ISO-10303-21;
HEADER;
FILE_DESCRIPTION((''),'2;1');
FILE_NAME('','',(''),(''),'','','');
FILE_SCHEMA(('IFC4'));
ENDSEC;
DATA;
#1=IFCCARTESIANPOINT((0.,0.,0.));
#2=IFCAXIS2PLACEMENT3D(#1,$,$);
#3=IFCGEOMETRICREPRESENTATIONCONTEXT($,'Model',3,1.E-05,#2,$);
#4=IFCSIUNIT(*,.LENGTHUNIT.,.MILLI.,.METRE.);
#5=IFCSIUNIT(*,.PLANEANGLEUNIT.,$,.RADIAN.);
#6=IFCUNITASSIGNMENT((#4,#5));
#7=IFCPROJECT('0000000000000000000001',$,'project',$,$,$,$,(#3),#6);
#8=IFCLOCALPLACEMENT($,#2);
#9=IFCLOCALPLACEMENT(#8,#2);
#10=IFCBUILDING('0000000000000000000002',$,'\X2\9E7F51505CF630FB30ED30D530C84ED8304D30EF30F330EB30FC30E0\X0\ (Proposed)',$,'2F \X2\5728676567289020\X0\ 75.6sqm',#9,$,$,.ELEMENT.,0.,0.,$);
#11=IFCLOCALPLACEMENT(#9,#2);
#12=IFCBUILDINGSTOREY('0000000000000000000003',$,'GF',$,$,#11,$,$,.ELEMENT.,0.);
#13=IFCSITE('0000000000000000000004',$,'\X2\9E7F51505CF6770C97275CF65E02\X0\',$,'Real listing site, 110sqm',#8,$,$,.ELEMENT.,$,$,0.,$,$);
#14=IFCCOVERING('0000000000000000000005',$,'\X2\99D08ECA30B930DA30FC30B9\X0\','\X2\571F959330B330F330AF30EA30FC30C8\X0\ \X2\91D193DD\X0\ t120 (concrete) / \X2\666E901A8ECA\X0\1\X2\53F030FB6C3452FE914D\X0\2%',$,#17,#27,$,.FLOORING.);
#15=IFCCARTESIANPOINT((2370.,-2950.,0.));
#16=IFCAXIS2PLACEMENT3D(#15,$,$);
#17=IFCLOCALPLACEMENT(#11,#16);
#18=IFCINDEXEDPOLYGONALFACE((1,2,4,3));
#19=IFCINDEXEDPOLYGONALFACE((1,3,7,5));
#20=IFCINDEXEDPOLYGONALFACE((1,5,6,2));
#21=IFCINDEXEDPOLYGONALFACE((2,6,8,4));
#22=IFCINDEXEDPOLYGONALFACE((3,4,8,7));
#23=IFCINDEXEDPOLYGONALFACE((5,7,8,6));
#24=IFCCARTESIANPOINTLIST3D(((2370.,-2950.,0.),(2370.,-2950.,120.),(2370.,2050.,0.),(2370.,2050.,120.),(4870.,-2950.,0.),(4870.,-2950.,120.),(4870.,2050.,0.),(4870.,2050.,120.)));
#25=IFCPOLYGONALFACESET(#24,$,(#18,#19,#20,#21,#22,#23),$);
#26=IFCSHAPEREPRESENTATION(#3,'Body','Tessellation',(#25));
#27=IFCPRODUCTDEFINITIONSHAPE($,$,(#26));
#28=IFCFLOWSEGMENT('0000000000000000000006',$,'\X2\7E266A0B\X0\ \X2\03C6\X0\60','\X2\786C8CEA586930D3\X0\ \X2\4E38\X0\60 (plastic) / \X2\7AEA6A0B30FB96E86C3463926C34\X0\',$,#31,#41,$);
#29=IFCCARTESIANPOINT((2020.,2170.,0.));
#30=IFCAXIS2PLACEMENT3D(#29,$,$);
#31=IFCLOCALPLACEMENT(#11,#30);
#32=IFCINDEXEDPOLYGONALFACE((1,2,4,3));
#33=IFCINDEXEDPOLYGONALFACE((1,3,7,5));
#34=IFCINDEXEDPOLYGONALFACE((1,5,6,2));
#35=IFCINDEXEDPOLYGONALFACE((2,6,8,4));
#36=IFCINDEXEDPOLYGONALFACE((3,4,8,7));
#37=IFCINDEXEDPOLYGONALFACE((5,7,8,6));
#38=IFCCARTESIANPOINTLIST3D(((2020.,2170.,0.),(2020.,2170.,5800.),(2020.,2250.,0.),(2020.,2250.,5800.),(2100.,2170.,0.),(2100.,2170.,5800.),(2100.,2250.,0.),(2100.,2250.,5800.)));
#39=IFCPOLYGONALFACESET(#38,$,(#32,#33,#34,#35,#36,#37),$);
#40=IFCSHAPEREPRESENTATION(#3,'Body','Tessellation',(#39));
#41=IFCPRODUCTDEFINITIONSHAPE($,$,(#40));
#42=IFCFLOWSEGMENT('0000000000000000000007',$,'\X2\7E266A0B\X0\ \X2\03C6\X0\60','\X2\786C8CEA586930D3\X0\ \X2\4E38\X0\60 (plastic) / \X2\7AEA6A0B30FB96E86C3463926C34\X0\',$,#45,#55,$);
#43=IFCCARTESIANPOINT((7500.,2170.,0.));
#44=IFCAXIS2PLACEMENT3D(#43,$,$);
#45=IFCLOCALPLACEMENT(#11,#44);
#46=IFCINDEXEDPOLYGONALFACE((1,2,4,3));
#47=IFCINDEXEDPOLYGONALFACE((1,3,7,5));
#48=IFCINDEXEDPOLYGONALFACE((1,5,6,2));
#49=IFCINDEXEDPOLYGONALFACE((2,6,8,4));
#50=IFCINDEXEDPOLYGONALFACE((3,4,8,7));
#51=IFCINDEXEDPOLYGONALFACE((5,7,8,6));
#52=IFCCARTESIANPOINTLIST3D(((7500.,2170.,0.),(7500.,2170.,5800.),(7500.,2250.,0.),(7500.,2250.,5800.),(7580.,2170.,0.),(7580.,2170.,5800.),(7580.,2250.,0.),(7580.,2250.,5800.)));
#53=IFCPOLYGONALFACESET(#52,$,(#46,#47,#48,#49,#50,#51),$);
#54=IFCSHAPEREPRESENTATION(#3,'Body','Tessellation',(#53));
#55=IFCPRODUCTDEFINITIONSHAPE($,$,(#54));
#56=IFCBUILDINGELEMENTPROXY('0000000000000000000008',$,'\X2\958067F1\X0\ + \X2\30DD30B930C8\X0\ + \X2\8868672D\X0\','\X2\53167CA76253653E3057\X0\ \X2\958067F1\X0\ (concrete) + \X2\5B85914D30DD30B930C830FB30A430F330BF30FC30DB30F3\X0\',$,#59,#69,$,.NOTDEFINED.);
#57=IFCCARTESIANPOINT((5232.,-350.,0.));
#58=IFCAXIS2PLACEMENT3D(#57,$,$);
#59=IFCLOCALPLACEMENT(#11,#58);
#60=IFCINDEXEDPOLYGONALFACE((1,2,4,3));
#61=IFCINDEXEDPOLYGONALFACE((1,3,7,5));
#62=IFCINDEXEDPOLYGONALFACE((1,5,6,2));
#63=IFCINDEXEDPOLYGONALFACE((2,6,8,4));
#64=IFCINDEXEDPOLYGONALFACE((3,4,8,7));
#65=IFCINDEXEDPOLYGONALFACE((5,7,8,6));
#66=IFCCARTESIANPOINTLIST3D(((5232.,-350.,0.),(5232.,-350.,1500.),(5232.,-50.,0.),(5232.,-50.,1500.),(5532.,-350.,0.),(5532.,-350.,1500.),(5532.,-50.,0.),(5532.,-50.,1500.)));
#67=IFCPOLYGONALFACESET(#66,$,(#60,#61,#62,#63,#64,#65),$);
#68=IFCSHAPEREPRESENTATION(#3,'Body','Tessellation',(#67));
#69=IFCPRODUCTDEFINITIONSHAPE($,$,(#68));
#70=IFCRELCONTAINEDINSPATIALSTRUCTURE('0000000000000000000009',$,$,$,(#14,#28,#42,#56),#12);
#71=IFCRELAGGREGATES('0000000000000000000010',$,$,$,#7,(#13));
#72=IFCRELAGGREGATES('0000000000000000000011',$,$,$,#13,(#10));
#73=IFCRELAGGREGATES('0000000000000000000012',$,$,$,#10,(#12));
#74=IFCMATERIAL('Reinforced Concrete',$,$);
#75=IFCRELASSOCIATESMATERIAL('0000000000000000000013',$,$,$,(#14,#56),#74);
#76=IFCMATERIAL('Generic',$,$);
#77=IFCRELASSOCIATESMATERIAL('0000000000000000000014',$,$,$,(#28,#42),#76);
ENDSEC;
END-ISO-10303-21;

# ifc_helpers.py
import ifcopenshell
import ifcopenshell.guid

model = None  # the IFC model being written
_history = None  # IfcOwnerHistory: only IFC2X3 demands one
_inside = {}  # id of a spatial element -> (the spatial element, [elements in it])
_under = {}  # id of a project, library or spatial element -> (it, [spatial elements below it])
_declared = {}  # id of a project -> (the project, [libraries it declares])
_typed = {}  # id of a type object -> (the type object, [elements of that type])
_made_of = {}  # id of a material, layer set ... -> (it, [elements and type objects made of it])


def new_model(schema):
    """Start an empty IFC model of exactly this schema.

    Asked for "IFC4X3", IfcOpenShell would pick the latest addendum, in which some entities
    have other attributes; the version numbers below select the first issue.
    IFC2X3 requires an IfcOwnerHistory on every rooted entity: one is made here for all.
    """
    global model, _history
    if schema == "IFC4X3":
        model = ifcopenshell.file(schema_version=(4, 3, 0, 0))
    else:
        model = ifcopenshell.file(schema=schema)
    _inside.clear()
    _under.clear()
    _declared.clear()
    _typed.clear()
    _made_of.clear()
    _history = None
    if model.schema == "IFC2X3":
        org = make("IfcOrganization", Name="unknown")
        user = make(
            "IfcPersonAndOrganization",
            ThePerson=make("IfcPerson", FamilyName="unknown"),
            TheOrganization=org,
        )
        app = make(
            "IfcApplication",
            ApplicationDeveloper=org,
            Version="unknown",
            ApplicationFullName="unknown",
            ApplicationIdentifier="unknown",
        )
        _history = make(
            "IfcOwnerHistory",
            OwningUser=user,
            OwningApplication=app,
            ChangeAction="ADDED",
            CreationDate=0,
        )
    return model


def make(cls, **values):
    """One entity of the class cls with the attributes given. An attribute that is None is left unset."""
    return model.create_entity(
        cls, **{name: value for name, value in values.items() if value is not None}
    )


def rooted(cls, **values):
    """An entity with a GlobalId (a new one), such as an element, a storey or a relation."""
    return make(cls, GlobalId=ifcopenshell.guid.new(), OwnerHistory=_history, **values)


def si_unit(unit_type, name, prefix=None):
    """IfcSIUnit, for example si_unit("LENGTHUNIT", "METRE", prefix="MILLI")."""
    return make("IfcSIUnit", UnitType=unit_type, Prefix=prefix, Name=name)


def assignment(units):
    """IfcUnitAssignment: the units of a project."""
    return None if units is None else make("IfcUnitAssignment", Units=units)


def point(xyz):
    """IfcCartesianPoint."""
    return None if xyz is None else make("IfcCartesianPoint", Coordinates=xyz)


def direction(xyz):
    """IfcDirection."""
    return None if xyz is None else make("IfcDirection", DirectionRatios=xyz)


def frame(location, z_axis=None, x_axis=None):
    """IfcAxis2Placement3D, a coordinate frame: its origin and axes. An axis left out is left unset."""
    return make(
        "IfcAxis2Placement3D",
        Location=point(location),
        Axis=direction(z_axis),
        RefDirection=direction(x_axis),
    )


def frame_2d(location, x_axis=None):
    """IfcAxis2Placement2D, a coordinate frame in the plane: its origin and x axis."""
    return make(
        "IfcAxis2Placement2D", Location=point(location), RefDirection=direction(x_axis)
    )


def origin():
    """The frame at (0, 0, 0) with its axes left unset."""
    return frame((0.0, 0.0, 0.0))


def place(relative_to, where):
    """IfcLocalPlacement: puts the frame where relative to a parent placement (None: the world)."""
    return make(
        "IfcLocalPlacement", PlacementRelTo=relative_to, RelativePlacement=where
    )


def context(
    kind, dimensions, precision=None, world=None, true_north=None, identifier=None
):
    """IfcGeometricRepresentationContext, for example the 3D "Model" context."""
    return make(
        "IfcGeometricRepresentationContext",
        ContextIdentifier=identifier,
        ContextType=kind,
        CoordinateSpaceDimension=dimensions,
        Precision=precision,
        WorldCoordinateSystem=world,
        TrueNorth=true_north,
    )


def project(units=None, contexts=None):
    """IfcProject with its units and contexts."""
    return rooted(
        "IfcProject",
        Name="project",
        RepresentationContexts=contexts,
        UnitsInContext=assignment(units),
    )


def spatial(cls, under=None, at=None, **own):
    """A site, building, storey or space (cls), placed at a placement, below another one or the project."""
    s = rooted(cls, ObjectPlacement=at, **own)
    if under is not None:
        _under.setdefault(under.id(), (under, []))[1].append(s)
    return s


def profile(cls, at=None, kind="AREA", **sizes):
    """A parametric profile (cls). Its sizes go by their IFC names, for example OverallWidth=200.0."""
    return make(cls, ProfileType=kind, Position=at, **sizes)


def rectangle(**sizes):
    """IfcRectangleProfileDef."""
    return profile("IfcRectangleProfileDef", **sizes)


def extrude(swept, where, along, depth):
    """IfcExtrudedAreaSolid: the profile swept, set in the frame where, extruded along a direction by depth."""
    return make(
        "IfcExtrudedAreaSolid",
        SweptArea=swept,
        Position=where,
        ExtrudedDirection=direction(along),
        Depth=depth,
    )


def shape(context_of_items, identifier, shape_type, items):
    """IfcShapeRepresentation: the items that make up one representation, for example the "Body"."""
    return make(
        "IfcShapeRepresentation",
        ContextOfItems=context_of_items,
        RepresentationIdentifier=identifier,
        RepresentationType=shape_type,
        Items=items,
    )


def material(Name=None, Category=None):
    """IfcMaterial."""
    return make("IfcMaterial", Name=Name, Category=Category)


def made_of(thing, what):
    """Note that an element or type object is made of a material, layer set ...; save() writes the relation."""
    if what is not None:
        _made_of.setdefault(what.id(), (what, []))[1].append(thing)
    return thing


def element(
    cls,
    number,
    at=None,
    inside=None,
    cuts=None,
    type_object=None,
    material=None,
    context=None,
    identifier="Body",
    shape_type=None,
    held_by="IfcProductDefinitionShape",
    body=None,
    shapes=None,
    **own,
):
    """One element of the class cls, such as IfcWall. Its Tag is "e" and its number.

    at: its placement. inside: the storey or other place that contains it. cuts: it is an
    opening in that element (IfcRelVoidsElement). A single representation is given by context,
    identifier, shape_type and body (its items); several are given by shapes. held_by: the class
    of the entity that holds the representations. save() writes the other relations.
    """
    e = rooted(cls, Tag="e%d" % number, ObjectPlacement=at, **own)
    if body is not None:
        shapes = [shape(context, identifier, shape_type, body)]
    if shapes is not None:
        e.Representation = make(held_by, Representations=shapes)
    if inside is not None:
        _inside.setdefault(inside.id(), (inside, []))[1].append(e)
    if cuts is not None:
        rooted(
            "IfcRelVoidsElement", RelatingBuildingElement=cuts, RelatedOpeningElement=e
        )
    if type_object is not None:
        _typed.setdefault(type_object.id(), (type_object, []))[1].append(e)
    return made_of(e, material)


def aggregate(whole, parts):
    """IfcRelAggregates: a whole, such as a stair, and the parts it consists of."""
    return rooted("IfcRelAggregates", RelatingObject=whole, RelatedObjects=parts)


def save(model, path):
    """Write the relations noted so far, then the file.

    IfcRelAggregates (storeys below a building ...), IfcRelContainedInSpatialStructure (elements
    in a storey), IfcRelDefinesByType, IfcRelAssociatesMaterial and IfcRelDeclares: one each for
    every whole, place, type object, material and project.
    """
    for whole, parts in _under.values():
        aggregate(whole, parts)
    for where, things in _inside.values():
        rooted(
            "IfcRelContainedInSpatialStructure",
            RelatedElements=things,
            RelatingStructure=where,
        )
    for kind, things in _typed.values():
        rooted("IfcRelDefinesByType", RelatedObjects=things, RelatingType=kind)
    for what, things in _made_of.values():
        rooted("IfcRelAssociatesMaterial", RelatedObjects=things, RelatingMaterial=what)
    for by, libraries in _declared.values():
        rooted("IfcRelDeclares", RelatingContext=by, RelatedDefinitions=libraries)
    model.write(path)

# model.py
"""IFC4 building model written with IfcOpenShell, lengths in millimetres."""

from ifc_helpers import new_model, si_unit, frame, frame_2d, origin, place, context, project, spatial, rectangle, extrude, material, element, save


model = new_model("IFC4")

# Units and contexts
model_context = context("Model", 3, precision=1e-05, world=origin())
ifc_project = project(units=[si_unit("LENGTHUNIT", "METRE", prefix="MILLI"), si_unit("PLANEANGLEUNIT", "RADIAN")], contexts=[model_context])

# Site, building, storey
site_placement = place(None, origin())
site = spatial("IfcSite", under=ifc_project, at=site_placement, Name="鹿児島県霧島市", ObjectType="Real listing site, 110sqm", CompositionType="ELEMENT", RefElevation=0.0)
building_placement = place(site_placement, origin())
building = spatial("IfcBuilding", under=site, at=building_placement, Name="鹿児島・ロフト付きワンルーム (Proposed)", ObjectType="2F 在来木造 75.6sqm", CompositionType="ELEMENT", ElevationOfRefHeight=0.0, ElevationOfTerrain=0.0)
storey_placement = place(building_placement, origin())
storey = spatial("IfcBuildingStorey", under=building, at=storey_placement, Name="GF", CompositionType="ELEMENT", Elevation=0.0)

# Shared definitions
ifc_material_1 = material(Name="Reinforced Concrete")

# Covering
covering_1_placement = place(storey_placement, frame((2370.0, -2950.0, 0.0)))
element("IfcCovering", 1, at=covering_1_placement, inside=storey, material=ifc_material_1, Name="駐車スペース", Description="土間コンクリート 金鏝 t120 (concrete) / 普通車1台・水勾配2%", PredefinedType="FLOORING", context=model_context, shape_type="SweptSolid", body=[
    extrude(rectangle(XDim=2500.0, YDim=5000.0, at=frame_2d((1250.0, 2500.0))), frame((2370.0, -2950.0, 0.0)), (0.0, 0.0, 1.0), 120.0),
])

# Flow segments
ifc_material_2 = material(Name="Generic")
flow_segment_1_placement = place(storey_placement, frame((2020.0, 2170.0, 0.0)))
element("IfcFlowSegment", 2, at=flow_segment_1_placement, inside=storey, material=ifc_material_2, Name="縦樋 φ60", Description="硬質塩ビ 丸60 (plastic) / 竪樋・雨水排水", context=model_context, shape_type="SweptSolid", body=[
    extrude(rectangle(XDim=80.0, YDim=80.0, at=frame_2d((40.0, 40.0))), frame((2020.0, 2170.0, 0.0)), (0.0, 0.0, 1.0), 5800.0),
])
flow_segment_2_placement = place(storey_placement, frame((7500.0, 2170.0, 0.0)))
element("IfcFlowSegment", 3, at=flow_segment_2_placement, inside=storey, material=ifc_material_2, Name="縦樋 φ60", Description="硬質塩ビ 丸60 (plastic) / 竪樋・雨水排水", context=model_context, shape_type="SweptSolid", body=[
    extrude(rectangle(XDim=80.0, YDim=80.0, at=frame_2d((40.0, 40.0))), frame((7500.0, 2170.0, 0.0)), (0.0, 0.0, 1.0), 5800.0),
])

# Building element proxy
proxy_placement = place(storey_placement, frame((5232.0, -350.0, 0.0)))
element("IfcBuildingElementProxy", 4, at=proxy_placement, inside=storey, material=ifc_material_1, Name="門柱 + ポスト + 表札", Description="化粧打放し 門柱 (concrete) + 宅配ポスト・インターホン", PredefinedType="NOTDEFINED", context=model_context, shape_type="SweptSolid", body=[
    extrude(rectangle(XDim=300.0, YDim=300.0, at=frame_2d((150.0, 150.0))), frame((5232.0, -350.0, 0.0)), (0.0, 0.0, 1.0), 1500.0),
])

save(model, "model.ifc")
